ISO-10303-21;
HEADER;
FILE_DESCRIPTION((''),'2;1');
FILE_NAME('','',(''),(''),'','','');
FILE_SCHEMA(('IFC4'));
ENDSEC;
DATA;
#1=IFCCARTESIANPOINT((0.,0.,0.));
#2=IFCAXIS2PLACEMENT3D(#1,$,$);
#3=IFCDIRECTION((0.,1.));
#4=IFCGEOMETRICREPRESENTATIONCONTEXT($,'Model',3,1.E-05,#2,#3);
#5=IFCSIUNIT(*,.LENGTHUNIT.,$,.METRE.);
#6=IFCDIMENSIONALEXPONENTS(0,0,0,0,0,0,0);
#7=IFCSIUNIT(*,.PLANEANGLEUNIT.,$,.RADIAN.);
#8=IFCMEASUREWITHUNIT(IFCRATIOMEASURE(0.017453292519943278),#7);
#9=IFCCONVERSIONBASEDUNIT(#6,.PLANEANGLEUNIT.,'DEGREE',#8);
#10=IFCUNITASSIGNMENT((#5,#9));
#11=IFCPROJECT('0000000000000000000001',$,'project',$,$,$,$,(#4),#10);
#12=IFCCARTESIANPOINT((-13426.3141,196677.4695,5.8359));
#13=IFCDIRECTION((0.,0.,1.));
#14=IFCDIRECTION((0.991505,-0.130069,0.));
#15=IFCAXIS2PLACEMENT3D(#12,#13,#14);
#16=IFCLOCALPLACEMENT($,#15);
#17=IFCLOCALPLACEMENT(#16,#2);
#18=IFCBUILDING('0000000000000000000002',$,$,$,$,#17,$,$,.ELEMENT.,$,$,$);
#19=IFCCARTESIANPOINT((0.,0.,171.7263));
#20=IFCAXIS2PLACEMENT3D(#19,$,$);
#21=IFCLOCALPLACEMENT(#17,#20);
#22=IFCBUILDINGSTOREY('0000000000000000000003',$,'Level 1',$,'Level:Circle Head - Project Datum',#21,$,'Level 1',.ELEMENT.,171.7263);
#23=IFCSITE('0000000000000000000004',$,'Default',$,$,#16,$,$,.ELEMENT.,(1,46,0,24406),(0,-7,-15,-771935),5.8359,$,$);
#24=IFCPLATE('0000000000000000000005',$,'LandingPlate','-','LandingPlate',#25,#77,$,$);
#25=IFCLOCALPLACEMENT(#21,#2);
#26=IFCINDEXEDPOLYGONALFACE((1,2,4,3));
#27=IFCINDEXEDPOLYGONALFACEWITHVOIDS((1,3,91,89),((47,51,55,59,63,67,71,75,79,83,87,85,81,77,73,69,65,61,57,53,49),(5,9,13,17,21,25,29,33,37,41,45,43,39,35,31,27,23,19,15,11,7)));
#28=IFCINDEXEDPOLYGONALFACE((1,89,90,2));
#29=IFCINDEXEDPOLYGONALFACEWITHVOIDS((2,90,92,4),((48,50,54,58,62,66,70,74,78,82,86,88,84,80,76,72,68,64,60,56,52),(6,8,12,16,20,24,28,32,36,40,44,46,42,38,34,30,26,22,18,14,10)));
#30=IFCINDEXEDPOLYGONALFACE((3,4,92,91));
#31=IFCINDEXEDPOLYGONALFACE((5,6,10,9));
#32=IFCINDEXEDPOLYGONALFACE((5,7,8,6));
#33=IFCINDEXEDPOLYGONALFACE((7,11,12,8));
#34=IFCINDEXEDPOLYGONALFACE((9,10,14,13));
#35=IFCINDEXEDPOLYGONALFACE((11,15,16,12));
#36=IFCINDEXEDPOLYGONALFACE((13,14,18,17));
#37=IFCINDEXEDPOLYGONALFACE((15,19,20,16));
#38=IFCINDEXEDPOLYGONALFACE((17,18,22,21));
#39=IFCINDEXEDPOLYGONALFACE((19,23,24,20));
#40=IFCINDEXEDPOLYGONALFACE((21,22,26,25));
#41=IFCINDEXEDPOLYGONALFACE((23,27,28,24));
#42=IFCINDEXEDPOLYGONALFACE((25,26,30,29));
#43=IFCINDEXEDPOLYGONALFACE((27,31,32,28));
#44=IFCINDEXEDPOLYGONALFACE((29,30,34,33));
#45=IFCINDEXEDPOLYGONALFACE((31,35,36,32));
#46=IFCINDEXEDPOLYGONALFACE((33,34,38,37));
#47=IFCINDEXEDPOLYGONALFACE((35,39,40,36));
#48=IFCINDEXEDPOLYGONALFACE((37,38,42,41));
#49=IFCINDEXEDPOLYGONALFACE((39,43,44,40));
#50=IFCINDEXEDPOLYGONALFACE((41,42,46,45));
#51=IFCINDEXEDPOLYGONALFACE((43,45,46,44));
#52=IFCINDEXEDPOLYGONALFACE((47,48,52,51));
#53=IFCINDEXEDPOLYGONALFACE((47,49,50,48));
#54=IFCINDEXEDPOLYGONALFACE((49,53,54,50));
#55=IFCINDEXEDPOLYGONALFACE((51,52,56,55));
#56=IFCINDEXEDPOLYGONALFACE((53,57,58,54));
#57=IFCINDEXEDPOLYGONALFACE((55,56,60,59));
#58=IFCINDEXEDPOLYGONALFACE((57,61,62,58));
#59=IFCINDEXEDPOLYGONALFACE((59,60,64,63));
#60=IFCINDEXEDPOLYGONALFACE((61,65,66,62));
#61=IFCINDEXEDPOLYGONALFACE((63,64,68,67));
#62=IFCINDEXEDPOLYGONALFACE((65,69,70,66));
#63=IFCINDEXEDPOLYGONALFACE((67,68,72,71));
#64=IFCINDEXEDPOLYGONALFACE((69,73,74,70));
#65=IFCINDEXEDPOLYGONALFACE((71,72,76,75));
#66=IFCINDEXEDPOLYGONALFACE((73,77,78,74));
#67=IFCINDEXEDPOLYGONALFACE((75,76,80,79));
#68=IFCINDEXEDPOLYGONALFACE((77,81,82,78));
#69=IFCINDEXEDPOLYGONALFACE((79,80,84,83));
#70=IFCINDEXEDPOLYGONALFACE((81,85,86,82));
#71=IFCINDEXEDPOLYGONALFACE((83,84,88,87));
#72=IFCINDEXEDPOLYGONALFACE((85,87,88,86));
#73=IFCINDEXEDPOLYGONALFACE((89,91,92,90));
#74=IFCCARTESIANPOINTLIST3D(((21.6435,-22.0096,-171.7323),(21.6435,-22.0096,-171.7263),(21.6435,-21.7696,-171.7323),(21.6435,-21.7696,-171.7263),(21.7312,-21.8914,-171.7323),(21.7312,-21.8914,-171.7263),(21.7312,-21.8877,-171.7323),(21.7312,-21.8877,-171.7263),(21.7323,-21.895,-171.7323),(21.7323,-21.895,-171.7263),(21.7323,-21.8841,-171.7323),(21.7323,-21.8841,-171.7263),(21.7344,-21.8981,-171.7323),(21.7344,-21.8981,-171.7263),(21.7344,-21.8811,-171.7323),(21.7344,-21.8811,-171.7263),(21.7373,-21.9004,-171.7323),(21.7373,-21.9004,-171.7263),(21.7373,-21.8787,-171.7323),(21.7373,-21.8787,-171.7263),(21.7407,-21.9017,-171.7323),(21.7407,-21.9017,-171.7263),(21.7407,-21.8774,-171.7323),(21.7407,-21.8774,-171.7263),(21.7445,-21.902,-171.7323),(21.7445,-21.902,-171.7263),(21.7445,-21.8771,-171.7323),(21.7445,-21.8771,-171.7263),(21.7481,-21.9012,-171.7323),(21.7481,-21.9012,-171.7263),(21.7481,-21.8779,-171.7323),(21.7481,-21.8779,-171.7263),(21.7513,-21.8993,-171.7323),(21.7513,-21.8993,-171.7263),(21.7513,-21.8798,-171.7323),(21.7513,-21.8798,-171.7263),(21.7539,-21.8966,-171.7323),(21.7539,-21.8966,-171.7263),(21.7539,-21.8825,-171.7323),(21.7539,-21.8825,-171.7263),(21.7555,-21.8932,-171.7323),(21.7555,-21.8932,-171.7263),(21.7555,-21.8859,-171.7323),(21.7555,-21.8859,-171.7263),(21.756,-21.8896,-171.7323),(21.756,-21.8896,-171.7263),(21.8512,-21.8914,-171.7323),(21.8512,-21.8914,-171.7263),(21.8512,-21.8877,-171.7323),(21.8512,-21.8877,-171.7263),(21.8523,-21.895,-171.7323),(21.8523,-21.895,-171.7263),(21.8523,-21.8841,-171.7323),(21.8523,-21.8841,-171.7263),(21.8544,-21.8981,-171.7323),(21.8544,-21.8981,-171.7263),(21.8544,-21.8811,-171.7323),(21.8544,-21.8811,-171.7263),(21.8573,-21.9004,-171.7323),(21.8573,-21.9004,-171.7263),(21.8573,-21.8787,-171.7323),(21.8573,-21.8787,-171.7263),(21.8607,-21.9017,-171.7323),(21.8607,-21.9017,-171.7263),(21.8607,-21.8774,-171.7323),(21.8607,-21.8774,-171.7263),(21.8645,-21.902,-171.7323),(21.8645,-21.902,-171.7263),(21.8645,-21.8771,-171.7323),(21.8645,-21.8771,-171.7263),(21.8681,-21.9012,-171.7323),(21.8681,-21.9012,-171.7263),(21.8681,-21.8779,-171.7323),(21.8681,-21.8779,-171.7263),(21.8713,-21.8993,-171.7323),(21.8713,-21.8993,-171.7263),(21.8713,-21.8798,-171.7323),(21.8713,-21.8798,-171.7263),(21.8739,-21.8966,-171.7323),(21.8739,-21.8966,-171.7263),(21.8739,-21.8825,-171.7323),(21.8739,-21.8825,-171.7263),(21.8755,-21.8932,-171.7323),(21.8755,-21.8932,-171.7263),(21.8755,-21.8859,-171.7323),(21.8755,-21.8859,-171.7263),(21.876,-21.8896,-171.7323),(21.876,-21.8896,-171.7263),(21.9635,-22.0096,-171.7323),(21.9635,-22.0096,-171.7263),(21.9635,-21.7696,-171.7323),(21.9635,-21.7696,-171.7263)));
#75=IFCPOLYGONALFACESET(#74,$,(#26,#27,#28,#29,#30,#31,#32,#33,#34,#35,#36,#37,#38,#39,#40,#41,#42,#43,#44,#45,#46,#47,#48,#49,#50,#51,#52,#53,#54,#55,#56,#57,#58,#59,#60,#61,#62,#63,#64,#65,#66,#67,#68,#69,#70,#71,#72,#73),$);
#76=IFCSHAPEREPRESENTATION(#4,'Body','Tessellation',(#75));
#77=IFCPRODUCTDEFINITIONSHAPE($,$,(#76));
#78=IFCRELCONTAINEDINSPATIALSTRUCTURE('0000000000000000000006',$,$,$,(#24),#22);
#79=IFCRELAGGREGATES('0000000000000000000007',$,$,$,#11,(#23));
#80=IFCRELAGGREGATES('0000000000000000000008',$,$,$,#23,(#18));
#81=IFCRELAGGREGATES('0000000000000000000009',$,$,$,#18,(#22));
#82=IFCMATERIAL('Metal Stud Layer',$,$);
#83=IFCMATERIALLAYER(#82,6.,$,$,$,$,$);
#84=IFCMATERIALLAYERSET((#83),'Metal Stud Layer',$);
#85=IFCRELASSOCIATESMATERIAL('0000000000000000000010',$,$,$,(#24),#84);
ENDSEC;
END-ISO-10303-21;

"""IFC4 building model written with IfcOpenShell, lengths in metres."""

from ifc_helpers import new_model, entity, si_unit, converted_unit, direction, frame, frame_2d, origin, origin_with_axes, place, context, project, spatial, polyline, circle, outline, extrude, material, layer, layer_set, element, save


model = new_model("IFC4")

# Units and contexts
model_context = context("Model", 3, precision=1e-05, world=origin(), true_north=direction((0.0, 1.0)))
ifc_project = project(units=[si_unit("LENGTHUNIT", "METRE"), converted_unit("PLANEANGLEUNIT", "DEGREE", entity("IfcRatioMeasure", 0.017453292519943278), si_unit("PLANEANGLEUNIT", "RADIAN"), dimensions=[0, 0, 0, 0, 0, 0, 0])], contexts=[model_context])

# Site, building, storey
site_placement = place(None, frame((-13426.3141, 196677.4695, 5.8359), z_axis=(0.0, 0.0, 1.0), x_axis=(0.991505, -0.130069, 0.0)))
site = spatial("IfcSite", under=ifc_project, at=site_placement, Name="Default", CompositionType="ELEMENT", RefLatitude=(1, 46, 0, 24406), RefLongitude=(0, -7, -15, -771935), RefElevation=5.8359)
building_placement = place(site_placement, origin())
building = spatial("IfcBuilding", under=site, at=building_placement, CompositionType="ELEMENT")
storey_placement = place(building_placement, frame((0.0, 0.0, 171.7263)))
storey = spatial("IfcBuildingStorey", under=building, at=storey_placement, Name="Level 1", ObjectType="Level:Circle Head - Project Datum", LongName="Level 1", CompositionType="ELEMENT", Elevation=171.7263)

# Plate, openings
ifc_material = material(Name="Metal Stud Layer")
ifc_layer_1 = layer(ifc_material, 6.0)
ifc_layer_set_1 = layer_set([ifc_layer_1], Name="Metal Stud Layer")
plate_1_placement = place(storey_placement, frame((21.8035, -21.8896, -171.7263), z_axis=(0.0, 0.0, -1.0), x_axis=(0.0, 1.0, 0.0)))
plate_1 = element("IfcPlate", 1, at=plate_1_placement, inside=storey, material=ifc_layer_set_1, Name="LandingPlate", Description="-", ObjectType="LandingPlate", context=model_context, shape_type="SweptSolid", body=[
    extrude(outline(polyline([(-0.12, -0.16), (0.12, -0.16), (0.12, 0.16), (-0.12, 0.16), (-0.12, -0.16)])), origin_with_axes(), (0.0, 0.0, 1.0), 0.006),
])
opening_1_placement = place(plate_1_placement, frame((0.0, 0.0, 0.0065), z_axis=(0.0, 0.0, -1.0), x_axis=(0.0, 1.0, 0.0)))
element("IfcOpeningElement", 2, at=opening_1_placement, cuts=plate_1, ObjectType="Opening", context=model_context, shape_type="SweptSolid", body=[
    extrude(circle(Radius=0.0125, at=frame_2d((0.06, 0.0), x_axis=(1.0, 0.0))), origin(), (0.0, 0.0, 1.0), 0.007),
])
opening_2_placement = place(plate_1_placement, frame((0.0, 0.0, 0.0065), z_axis=(0.0, 0.0, -1.0), x_axis=(0.0, 1.0, 0.0)))
element("IfcOpeningElement", 3, at=opening_2_placement, cuts=plate_1, ObjectType="Opening", context=model_context, shape_type="SweptSolid", body=[
    extrude(circle(Radius=0.0125, at=frame_2d((-0.06, 0.0), x_axis=(1.0, 0.0))), origin(), (0.0, 0.0, 1.0), 0.007),
])

save(model, "model.ifc")
